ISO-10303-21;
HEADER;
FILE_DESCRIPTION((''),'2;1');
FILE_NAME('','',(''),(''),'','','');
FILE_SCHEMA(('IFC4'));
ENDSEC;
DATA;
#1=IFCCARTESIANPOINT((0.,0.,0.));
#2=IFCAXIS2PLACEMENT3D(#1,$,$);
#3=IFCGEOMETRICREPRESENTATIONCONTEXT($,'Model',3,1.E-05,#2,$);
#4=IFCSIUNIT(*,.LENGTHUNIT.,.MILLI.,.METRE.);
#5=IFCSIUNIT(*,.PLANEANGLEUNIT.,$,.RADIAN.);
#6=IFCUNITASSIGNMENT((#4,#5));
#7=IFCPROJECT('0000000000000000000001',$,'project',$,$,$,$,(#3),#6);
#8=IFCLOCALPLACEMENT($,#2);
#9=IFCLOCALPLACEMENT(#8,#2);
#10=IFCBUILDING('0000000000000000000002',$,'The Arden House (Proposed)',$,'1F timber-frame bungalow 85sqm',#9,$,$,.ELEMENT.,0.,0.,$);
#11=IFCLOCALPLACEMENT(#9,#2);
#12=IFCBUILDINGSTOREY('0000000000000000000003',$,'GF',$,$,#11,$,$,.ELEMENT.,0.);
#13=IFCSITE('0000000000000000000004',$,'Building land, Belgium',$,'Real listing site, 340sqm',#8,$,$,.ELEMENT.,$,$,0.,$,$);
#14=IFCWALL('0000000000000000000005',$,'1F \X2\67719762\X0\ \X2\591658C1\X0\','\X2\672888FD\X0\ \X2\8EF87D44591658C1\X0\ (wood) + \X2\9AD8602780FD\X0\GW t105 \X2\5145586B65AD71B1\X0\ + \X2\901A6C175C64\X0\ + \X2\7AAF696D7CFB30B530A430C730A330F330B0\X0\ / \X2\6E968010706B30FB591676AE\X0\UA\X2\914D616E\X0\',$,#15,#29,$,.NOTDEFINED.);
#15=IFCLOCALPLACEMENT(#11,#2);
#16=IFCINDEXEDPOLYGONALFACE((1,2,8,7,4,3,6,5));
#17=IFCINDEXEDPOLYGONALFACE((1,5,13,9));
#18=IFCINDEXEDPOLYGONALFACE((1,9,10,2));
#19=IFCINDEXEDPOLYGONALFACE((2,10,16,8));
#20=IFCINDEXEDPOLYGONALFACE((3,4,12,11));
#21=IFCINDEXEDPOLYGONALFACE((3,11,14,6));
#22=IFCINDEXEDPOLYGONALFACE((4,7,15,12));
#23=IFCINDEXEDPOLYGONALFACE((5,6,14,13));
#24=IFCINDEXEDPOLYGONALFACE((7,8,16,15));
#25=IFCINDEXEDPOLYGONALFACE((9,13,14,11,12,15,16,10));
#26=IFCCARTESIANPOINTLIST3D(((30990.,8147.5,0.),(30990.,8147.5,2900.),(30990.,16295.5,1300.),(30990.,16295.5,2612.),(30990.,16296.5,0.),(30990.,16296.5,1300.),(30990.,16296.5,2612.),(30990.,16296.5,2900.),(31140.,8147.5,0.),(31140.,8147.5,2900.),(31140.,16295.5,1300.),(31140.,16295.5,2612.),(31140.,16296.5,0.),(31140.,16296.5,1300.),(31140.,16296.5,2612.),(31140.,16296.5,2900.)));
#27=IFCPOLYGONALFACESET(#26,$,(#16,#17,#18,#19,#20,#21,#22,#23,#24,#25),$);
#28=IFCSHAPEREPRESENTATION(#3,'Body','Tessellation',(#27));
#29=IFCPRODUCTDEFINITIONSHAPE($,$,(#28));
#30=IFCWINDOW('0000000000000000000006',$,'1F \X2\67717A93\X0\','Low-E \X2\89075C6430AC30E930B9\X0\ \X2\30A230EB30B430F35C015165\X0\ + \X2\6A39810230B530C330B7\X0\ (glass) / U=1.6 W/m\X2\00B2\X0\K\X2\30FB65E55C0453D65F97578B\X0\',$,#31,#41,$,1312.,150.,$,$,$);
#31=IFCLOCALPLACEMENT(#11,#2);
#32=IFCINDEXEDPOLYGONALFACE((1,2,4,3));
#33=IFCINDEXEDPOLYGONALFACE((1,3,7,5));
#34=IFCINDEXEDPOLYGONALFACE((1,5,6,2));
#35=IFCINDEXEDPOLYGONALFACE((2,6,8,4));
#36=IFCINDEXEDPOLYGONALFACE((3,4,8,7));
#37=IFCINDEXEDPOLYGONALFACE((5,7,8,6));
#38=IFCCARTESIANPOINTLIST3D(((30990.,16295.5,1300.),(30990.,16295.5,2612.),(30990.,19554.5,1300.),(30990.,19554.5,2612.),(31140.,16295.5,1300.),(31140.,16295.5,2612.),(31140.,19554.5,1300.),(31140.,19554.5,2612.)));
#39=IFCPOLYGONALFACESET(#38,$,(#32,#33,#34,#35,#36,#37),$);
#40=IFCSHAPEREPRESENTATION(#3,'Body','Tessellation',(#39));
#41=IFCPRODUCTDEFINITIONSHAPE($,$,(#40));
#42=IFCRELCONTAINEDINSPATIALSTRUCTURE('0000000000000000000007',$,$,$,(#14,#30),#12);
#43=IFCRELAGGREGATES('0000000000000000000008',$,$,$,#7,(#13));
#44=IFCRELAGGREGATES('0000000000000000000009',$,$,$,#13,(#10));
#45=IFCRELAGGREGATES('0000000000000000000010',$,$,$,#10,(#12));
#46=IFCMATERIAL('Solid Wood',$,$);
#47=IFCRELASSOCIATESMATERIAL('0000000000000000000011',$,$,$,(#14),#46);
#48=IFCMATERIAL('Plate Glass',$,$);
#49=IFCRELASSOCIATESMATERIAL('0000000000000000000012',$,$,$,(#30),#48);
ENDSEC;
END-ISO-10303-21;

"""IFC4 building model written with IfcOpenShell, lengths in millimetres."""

from ifc_helpers import new_model, si_unit, frame, frame_2d, origin, place, context, project, spatial, rectangle, extrude, material, element, fill, save


model = new_model("IFC4")

# Units and contexts
model_context = context("Model", 3, precision=1e-05, world=origin())
ifc_project = project(units=[si_unit("LENGTHUNIT", "METRE", prefix="MILLI"), si_unit("PLANEANGLEUNIT", "RADIAN")], contexts=[model_context])

# Site, building, storey
site_placement = place(None, origin())
site = spatial("IfcSite", under=ifc_project, at=site_placement, Name="Building land, Belgium", ObjectType="Real listing site, 340sqm", CompositionType="ELEMENT", RefElevation=0.0)
building_placement = place(site_placement, origin())
building = spatial("IfcBuilding", under=site, at=building_placement, Name="The Arden House (Proposed)", ObjectType="1F timber-frame bungalow 85sqm", CompositionType="ELEMENT", ElevationOfRefHeight=0.0, ElevationOfTerrain=0.0)
storey_placement = place(building_placement, origin())
storey = spatial("IfcBuildingStorey", under=building, at=storey_placement, Name="GF", CompositionType="ELEMENT", Elevation=0.0)

# Shared definitions
ifc_material_1 = material(Name="Solid Wood")

# Wall, opening, window
wall_1_placement = place(storey_placement, frame((15495.0, 4074.0, 0.0)))
wall_1 = element("IfcWall", 1, at=wall_1_placement, inside=storey, material=ifc_material_1, Name="1F 東面 外壁", Description="木製 軸組外壁 (wood) + 高性能GW t105 充填断熱 + 通気層 + 窯業系サイディング / 準耐火・外皮UA配慮", PredefinedType="NOTDEFINED", context=model_context, shape_type="SweptSolid", body=[
    extrude(rectangle(XDim=150.0, YDim=8149.0, at=frame_2d((75.0, 4074.0))), frame((15495.0, 4074.0, 0.0)), (0.0, 0.0, 1.0), 2900.0),
])
opening_placement = place(storey_placement, frame((15495.0, 8148.0, 650.0)))
opening = element("IfcOpeningElement", 2, at=opening_placement, cuts=wall_1, PredefinedType="NOTDEFINED", context=model_context, shape_type="SweptSolid", body=[
    extrude(rectangle(XDim=150.0, YDim=3259.0, at=frame_2d((75.0, 1629.0))), frame((15495.0, 8148.0, 650.0)), (0.0, 0.0, 1.0), 1312.0),
])
ifc_material_2 = material(Name="Plate Glass")
window_placement = place(storey_placement, frame((15495.0, 8148.0, 650.0)))
window = element("IfcWindow", 3, at=window_placement, inside=storey, material=ifc_material_2, Name="1F 東窓", Description="Low-E 複層ガラス アルゴン封入 + 樹脂サッシ (glass) / U=1.6 W/m²K・日射取得型", OverallHeight=1312.0, OverallWidth=150.0, context=model_context, shape_type="SweptSolid", body=[
    extrude(rectangle(XDim=150.0, YDim=3259.0, at=frame_2d((75.0, 1629.0))), frame((15495.0, 8148.0, 650.0)), (0.0, 0.0, 1.0), 1312.0),
])
fill(opening, window)

save(model, "model.ifc")
